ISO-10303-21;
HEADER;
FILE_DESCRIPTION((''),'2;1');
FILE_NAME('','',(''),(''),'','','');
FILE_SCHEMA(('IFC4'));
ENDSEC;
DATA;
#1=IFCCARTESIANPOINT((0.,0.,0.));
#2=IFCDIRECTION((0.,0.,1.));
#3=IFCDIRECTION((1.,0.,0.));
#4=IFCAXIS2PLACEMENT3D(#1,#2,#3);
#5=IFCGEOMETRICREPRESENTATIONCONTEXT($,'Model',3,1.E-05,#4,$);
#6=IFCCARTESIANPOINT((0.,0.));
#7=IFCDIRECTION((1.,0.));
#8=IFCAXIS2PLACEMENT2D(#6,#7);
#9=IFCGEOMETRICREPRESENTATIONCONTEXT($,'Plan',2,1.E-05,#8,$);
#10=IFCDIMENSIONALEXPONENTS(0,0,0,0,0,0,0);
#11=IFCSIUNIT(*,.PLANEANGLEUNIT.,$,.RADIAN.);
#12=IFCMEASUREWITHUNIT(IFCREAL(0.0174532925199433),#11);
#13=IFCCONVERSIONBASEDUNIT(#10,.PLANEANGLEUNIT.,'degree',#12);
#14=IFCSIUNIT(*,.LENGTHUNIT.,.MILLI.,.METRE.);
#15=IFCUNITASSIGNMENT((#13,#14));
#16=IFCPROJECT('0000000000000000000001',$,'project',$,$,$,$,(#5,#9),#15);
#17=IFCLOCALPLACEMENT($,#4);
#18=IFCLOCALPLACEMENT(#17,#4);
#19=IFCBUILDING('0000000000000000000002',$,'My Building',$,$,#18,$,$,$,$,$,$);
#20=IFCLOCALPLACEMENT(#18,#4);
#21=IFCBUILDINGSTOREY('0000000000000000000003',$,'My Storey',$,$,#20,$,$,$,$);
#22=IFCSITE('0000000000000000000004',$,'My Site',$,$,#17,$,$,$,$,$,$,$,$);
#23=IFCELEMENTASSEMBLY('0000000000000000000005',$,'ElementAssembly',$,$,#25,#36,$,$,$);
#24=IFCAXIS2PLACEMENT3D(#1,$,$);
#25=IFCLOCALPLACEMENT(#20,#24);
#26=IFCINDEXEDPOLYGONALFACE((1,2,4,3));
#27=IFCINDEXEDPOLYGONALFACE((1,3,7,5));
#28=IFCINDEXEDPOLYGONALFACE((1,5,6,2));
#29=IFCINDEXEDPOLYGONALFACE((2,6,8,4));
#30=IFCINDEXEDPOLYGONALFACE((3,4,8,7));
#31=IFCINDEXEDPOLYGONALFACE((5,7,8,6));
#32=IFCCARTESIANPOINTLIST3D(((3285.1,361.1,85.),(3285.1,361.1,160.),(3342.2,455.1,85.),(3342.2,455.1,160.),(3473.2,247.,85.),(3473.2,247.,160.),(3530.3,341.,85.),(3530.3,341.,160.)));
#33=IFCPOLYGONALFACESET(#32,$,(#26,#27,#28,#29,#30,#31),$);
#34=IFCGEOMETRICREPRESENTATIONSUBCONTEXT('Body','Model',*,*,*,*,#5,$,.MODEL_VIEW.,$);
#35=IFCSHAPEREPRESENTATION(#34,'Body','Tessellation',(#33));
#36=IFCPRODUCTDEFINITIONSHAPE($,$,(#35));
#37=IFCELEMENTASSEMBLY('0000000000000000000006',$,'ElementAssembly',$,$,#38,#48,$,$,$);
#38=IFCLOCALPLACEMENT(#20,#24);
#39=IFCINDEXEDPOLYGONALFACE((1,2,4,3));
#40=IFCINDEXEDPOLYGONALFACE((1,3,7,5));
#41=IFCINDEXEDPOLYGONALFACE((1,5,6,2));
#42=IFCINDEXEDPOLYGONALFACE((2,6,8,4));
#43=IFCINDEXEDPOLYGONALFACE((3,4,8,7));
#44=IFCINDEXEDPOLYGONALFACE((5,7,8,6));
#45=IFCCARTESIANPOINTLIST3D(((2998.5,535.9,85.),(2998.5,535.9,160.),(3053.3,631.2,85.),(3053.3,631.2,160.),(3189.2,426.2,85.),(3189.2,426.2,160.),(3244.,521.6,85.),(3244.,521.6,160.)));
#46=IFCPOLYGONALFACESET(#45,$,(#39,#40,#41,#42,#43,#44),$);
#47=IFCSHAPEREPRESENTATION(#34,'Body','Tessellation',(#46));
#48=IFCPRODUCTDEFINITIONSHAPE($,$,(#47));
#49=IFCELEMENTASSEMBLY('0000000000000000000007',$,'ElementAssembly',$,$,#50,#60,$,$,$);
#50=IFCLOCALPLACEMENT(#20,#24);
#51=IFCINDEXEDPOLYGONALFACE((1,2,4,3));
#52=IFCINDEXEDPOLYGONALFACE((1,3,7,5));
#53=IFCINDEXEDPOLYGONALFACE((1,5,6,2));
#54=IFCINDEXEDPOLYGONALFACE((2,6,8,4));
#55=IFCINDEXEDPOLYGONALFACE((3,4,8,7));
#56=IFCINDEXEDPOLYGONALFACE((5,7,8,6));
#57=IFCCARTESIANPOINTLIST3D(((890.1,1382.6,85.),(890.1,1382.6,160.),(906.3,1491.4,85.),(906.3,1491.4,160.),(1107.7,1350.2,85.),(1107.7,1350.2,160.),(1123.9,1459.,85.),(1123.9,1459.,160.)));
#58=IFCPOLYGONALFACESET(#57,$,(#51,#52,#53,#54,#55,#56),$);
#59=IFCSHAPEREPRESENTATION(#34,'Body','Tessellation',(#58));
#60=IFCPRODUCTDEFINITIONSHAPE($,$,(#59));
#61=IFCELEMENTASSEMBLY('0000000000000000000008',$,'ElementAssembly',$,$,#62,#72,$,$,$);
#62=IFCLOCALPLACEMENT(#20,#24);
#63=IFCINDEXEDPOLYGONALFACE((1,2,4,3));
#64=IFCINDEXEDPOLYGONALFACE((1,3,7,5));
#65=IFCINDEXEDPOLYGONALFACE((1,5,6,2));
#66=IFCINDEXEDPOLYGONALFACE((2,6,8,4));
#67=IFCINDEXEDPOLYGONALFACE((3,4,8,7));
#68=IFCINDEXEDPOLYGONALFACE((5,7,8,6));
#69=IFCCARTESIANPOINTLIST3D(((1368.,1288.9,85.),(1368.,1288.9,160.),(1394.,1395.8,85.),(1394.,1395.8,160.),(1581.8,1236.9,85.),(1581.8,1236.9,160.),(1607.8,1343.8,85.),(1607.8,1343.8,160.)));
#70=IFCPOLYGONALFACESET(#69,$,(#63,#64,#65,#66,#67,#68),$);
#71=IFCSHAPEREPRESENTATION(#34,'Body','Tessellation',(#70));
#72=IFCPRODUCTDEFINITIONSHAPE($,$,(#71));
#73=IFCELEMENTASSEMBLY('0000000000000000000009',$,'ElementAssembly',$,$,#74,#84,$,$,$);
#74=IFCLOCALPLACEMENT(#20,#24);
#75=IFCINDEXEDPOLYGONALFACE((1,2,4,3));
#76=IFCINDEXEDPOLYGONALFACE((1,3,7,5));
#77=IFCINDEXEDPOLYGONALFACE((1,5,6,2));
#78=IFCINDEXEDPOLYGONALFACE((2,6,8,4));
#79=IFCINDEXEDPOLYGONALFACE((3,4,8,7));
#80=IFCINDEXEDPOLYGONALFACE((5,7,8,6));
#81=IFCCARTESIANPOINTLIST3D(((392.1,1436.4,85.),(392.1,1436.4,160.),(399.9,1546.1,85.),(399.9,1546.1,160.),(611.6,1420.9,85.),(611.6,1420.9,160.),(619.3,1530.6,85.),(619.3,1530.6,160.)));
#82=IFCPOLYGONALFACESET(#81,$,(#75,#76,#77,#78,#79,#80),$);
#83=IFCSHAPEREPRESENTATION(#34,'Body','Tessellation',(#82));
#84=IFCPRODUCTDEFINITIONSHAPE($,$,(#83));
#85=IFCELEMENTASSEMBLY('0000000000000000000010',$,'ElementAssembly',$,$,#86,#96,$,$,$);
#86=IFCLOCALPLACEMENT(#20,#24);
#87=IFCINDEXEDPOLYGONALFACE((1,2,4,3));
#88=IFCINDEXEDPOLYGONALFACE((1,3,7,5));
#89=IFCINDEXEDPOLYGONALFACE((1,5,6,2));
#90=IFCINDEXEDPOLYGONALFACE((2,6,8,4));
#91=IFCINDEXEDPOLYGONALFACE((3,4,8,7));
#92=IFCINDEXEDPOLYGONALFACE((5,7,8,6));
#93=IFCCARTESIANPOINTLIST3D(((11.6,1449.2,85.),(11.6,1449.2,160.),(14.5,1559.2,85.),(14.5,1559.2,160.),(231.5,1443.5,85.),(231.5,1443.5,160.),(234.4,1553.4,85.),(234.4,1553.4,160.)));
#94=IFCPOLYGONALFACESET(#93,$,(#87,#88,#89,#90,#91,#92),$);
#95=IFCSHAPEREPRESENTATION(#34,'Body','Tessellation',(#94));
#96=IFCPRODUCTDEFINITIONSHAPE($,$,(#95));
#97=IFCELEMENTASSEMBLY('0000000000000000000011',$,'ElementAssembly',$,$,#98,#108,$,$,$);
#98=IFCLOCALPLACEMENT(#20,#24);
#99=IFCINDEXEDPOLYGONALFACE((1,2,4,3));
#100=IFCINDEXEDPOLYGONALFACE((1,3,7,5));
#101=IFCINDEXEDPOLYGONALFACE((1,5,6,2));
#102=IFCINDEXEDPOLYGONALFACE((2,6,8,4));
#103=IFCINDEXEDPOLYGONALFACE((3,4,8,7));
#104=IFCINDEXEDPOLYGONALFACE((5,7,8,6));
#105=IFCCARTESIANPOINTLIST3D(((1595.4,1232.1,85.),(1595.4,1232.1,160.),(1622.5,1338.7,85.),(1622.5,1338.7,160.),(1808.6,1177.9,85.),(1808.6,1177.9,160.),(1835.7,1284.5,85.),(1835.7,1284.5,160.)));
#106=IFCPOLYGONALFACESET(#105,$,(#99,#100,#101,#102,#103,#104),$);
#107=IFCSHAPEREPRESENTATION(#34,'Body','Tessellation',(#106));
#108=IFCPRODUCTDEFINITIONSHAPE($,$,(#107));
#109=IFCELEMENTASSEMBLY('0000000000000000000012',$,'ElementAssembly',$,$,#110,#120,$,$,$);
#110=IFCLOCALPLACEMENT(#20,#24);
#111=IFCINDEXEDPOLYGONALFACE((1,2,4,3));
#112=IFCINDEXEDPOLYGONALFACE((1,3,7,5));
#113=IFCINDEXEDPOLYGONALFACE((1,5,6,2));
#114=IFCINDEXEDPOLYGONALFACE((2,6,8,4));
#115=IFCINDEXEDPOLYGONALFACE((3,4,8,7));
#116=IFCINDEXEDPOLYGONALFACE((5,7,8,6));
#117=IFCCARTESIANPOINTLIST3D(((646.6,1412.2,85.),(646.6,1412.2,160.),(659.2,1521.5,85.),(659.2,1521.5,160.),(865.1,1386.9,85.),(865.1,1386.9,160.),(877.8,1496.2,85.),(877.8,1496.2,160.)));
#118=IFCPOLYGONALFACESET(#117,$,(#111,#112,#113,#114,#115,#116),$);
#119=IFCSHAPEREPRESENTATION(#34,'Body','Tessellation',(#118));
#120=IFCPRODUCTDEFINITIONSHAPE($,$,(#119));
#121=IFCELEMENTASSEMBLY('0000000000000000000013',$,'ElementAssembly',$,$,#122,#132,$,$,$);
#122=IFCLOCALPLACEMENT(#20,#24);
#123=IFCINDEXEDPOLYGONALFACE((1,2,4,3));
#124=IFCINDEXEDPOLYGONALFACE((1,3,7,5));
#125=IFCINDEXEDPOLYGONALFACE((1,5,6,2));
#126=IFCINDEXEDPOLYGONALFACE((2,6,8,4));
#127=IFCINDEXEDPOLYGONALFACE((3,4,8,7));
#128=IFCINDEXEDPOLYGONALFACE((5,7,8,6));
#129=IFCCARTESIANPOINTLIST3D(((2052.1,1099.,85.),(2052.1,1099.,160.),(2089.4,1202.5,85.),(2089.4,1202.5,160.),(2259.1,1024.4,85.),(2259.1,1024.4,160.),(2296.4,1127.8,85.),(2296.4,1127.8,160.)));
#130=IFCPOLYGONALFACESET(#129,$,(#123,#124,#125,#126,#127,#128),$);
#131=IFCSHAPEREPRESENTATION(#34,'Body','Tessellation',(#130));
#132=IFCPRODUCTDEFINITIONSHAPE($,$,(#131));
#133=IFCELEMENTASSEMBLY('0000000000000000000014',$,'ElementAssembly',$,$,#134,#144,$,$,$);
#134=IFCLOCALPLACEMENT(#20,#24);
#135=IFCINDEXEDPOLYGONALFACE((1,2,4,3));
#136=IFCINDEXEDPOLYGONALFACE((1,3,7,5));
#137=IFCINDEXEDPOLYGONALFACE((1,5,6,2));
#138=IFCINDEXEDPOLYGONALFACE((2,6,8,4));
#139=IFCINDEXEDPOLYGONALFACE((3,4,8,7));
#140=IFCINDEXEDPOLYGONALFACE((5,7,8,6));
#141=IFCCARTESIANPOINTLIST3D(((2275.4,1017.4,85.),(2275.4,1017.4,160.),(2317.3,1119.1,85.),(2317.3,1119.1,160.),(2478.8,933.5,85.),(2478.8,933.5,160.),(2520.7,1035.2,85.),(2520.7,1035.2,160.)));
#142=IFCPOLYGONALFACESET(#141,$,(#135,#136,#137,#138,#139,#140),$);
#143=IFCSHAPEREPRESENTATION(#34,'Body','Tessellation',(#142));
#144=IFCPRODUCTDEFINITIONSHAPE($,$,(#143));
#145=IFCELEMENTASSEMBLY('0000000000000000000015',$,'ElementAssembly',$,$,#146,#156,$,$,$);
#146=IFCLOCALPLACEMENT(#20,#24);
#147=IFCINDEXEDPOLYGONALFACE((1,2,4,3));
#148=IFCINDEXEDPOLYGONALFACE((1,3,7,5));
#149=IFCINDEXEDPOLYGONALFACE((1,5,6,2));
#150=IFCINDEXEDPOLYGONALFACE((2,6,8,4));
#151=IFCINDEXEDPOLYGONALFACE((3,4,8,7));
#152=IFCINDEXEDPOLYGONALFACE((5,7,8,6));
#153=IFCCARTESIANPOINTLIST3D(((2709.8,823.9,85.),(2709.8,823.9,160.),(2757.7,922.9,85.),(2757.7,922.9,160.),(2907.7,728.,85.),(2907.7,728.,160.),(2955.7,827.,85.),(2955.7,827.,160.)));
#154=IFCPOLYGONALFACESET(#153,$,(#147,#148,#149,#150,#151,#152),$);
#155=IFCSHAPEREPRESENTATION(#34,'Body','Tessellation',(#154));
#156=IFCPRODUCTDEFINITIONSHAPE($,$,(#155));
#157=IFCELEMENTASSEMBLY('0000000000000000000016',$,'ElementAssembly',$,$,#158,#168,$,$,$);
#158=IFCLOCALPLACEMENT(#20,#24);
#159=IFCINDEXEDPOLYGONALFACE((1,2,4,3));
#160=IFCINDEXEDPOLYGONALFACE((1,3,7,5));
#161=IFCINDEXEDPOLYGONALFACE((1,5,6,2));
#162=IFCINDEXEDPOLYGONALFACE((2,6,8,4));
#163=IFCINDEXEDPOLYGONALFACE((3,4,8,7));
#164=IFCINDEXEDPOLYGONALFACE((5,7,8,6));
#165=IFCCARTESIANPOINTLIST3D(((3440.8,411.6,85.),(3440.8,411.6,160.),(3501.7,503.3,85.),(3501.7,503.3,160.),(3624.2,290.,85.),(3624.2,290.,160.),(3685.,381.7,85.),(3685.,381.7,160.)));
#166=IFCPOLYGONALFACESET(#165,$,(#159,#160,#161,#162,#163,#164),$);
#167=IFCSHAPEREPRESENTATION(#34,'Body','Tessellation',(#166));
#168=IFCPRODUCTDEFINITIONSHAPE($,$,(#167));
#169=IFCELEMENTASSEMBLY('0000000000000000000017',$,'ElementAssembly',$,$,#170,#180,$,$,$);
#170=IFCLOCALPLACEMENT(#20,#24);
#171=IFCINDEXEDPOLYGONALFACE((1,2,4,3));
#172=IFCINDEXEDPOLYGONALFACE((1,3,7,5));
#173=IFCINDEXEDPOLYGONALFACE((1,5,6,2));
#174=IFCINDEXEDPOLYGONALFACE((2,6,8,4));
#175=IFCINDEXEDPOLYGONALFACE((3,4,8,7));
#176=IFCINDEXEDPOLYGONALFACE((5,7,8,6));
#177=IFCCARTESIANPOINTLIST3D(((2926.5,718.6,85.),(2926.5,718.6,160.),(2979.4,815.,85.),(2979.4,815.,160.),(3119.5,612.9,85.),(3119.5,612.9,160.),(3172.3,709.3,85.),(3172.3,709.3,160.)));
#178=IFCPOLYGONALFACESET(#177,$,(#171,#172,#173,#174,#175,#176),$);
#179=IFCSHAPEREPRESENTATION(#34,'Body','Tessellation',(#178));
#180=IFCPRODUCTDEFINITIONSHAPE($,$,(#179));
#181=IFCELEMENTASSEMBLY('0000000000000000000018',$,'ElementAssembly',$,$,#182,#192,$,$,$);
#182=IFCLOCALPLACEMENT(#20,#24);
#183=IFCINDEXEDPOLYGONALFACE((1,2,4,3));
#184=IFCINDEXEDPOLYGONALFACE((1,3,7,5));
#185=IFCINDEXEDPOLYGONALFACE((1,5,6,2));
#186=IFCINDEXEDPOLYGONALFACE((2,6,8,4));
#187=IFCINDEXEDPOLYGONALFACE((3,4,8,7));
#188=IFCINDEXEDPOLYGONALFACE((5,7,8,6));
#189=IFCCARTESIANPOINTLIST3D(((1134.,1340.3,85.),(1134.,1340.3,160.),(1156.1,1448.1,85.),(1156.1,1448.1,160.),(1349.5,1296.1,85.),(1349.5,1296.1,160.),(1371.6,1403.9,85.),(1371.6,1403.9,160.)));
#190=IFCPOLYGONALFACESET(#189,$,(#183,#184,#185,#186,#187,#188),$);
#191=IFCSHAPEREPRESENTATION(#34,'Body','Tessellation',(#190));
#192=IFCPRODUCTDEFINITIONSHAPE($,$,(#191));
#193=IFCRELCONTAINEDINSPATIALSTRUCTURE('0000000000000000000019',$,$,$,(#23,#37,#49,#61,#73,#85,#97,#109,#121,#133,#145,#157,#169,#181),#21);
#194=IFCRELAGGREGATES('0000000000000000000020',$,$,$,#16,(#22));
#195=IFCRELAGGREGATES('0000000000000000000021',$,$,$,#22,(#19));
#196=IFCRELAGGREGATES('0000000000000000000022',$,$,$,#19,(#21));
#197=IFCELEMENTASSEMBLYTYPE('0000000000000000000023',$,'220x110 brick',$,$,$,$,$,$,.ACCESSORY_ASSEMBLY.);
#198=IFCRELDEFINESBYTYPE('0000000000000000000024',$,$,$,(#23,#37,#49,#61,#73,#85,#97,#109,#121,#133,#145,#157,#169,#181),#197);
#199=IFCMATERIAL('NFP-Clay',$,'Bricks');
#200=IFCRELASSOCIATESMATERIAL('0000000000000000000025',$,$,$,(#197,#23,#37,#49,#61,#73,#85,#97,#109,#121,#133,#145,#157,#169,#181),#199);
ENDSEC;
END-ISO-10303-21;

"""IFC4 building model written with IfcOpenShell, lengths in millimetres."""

from ifc_helpers import new_model, entity, si_unit, converted_unit, frame, origin_with_axes, origin_2d_with_axis, place, context, subcontext, project, spatial, rectangle, extrude, material, material_profile, profile_set, profile_usage, type_object, element, save


model = new_model("IFC4")

# Units and contexts
model_context = context("Model", 3, precision=1e-05, world=origin_with_axes())
plan_context = context("Plan", 2, precision=1e-05, world=origin_2d_with_axis())
body_context = subcontext(model_context, "Body", "Model", "MODEL_VIEW")
ifc_project = project(units=[converted_unit("PLANEANGLEUNIT", "degree", entity("IfcReal", 0.0174532925199433), si_unit("PLANEANGLEUNIT", "RADIAN"), dimensions=[0, 0, 0, 0, 0, 0, 0]), si_unit("LENGTHUNIT", "METRE", prefix="MILLI")], contexts=[model_context, plan_context])

# Site, building, storey
site_placement = place(None, origin_with_axes())
site = spatial("IfcSite", under=ifc_project, at=site_placement, Name="My Site")
building_placement = place(site_placement, origin_with_axes())
building = spatial("IfcBuilding", under=site, at=building_placement, Name="My Building")
storey_placement = place(building_placement, origin_with_axes())
storey = spatial("IfcBuildingStorey", under=building, at=storey_placement, Name="My Storey")

# Element assemblies
ifc_material_1 = material(Name="NFP-Clay", Category="Bricks")
ifc_material_profile_1 = material_profile(ifc_material_1, rectangle(XDim=220.0, YDim=110.0))
ifc_profile_set_1 = profile_set([ifc_material_profile_1])
element_assembly_type_1 = type_object("IfcElementAssemblyType", Name="220x110 brick", PredefinedType="ACCESSORY_ASSEMBLY", material=ifc_profile_set_1)
ifc_profile_usage_1 = profile_usage(ifc_profile_set_1, cardinal=5)
assembly_1_placement = place(storey_placement, frame((3407.7, 351.0, 85.0), z_axis=(0.0, 0.0, 1.0), x_axis=(0.854897, -0.518798, 0.0)))
element("IfcElementAssembly", 1, at=assembly_1_placement, inside=storey, type_object=element_assembly_type_1, material=ifc_profile_usage_1, Name="ElementAssembly", context=body_context, shape_type="SweptSolid", body=[
    extrude(rectangle(XDim=220.0, YDim=110.0), origin_with_axes(), (0.0, 0.0, 1.0), 75.0),
])
ifc_profile_usage_2 = profile_usage(ifc_profile_set_1, cardinal=5)
assembly_2_placement = place(storey_placement, frame((3121.3, 528.7, 85.0), z_axis=(0.0, 0.0, 1.0), x_axis=(0.86697, -0.498361, 0.0)))
element("IfcElementAssembly", 2, at=assembly_2_placement, inside=storey, type_object=element_assembly_type_1, material=ifc_profile_usage_2, Name="ElementAssembly", context=body_context, shape_type="SweptSolid", body=[
    extrude(rectangle(XDim=220.0, YDim=110.0), origin_with_axes(), (0.0, 0.0, 1.0), 75.0),
])
ifc_profile_usage_3 = profile_usage(ifc_profile_set_1, cardinal=5)
assembly_3_placement = place(storey_placement, frame((1007.0, 1420.8, 85.0), z_axis=(0.0, 0.0, 1.0), x_axis=(0.989094, -0.147289, 0.0)))
element("IfcElementAssembly", 3, at=assembly_3_placement, inside=storey, type_object=element_assembly_type_1, material=ifc_profile_usage_3, Name="ElementAssembly", context=body_context, shape_type="SweptSolid", body=[
    extrude(rectangle(XDim=220.0, YDim=110.0), origin_with_axes(), (0.0, 0.0, 1.0), 75.0),
])
ifc_profile_usage_4 = profile_usage(ifc_profile_set_1, cardinal=5)
assembly_4_placement = place(storey_placement, frame((1487.9, 1316.4, 85.0), z_axis=(0.0, 0.0, 1.0), x_axis=(0.971752, -0.236002, 0.0)))
element("IfcElementAssembly", 4, at=assembly_4_placement, inside=storey, type_object=element_assembly_type_1, material=ifc_profile_usage_4, Name="ElementAssembly", context=body_context, shape_type="SweptSolid", body=[
    extrude(rectangle(XDim=220.0, YDim=110.0), origin_with_axes(), (0.0, 0.0, 1.0), 75.0),
])
ifc_profile_usage_5 = profile_usage(ifc_profile_set_1, cardinal=5)
assembly_5_placement = place(storey_placement, frame((505.7, 1483.5, 85.0), z_axis=(0.0, 0.0, 1.0), x_axis=(0.997514, -0.070472, 0.0)))
element("IfcElementAssembly", 5, at=assembly_5_placement, inside=storey, type_object=element_assembly_type_1, material=ifc_profile_usage_5, Name="ElementAssembly", context=body_context, shape_type="SweptSolid", body=[
    extrude(rectangle(XDim=220.0, YDim=110.0), origin_with_axes(), (0.0, 0.0, 1.0), 75.0),
])
ifc_profile_usage_6 = profile_usage(ifc_profile_set_1, cardinal=5)
assembly_6_placement = place(storey_placement, frame((123.0, 1501.3, 85.0), z_axis=(0.0, 0.0, 1.0), x_axis=(0.999659, -0.0261, 0.0)))
element("IfcElementAssembly", 6, at=assembly_6_placement, inside=storey, type_object=element_assembly_type_1, material=ifc_profile_usage_6, Name="ElementAssembly", context=body_context, shape_type="SweptSolid", body=[
    extrude(rectangle(XDim=220.0, YDim=110.0), origin_with_axes(), (0.0, 0.0, 1.0), 75.0),
])
ifc_profile_usage_7 = profile_usage(ifc_profile_set_1, cardinal=5)
assembly_7_placement = place(storey_placement, frame((1715.6, 1258.3, 85.0), z_axis=(0.0, 0.0, 1.0), x_axis=(0.96918, -0.246355, 0.0)))
element("IfcElementAssembly", 7, at=assembly_7_placement, inside=storey, type_object=element_assembly_type_1, material=ifc_profile_usage_7, Name="ElementAssembly", context=body_context, shape_type="SweptSolid", body=[
    extrude(rectangle(XDim=220.0, YDim=110.0), origin_with_axes(), (0.0, 0.0, 1.0), 75.0),
])
ifc_profile_usage_8 = profile_usage(ifc_profile_set_1, cardinal=5)
assembly_8_placement = place(storey_placement, frame((762.2, 1454.2, 85.0), z_axis=(0.0, 0.0, 1.0), x_axis=(0.993374, -0.114928, 0.0)))
element("IfcElementAssembly", 8, at=assembly_8_placement, inside=storey, type_object=element_assembly_type_1, material=ifc_profile_usage_8, Name="ElementAssembly", context=body_context, shape_type="SweptSolid", body=[
    extrude(rectangle(XDim=220.0, YDim=110.0), origin_with_axes(), (0.0, 0.0, 1.0), 75.0),
])
ifc_profile_usage_9 = profile_usage(ifc_profile_set_1, cardinal=5)
assembly_9_placement = place(storey_placement, frame((2174.3, 1113.4, 85.0), z_axis=(0.0, 0.0, 1.0), x_axis=(0.940653, -0.33937, 0.0)))
element("IfcElementAssembly", 9, at=assembly_9_placement, inside=storey, type_object=element_assembly_type_1, material=ifc_profile_usage_9, Name="ElementAssembly", context=body_context, shape_type="SweptSolid", body=[
    extrude(rectangle(XDim=220.0, YDim=110.0), origin_with_axes(), (0.0, 0.0, 1.0), 75.0),
])
ifc_profile_usage_10 = profile_usage(ifc_profile_set_1, cardinal=5)
assembly_10_placement = place(storey_placement, frame((2398.0, 1026.3, 85.0), z_axis=(0.0, 0.0, 1.0), x_axis=(0.924566, -0.381021, 0.0)))
element("IfcElementAssembly", 10, at=assembly_10_placement, inside=storey, type_object=element_assembly_type_1, material=ifc_profile_usage_10, Name="ElementAssembly", context=body_context, shape_type="SweptSolid", body=[
    extrude(rectangle(XDim=220.0, YDim=110.0), origin_with_axes(), (0.0, 0.0, 1.0), 75.0),
])
ifc_profile_usage_11 = profile_usage(ifc_profile_set_1, cardinal=5)
assembly_11_placement = place(storey_placement, frame((2832.7, 825.5, 85.0), z_axis=(0.0, 0.0, 1.0), x_axis=(0.899844, -0.436212, 0.0)))
element("IfcElementAssembly", 11, at=assembly_11_placement, inside=storey, type_object=element_assembly_type_1, material=ifc_profile_usage_11, Name="ElementAssembly", context=body_context, shape_type="SweptSolid", body=[
    extrude(rectangle(XDim=220.0, YDim=110.0), origin_with_axes(), (0.0, 0.0, 1.0), 75.0),
])
ifc_profile_usage_12 = profile_usage(ifc_profile_set_1, cardinal=5)
assembly_12_placement = place(storey_placement, frame((3562.9, 396.6, 85.0), z_axis=(0.0, 0.0, 1.0), x_axis=(0.833305, -0.552813, 0.0)))
element("IfcElementAssembly", 12, at=assembly_12_placement, inside=storey, type_object=element_assembly_type_1, material=ifc_profile_usage_12, Name="ElementAssembly", context=body_context, shape_type="SweptSolid", body=[
    extrude(rectangle(XDim=220.0, YDim=110.0), origin_with_axes(), (0.0, 0.0, 1.0), 75.0),
])
ifc_profile_usage_13 = profile_usage(ifc_profile_set_1, cardinal=5)
assembly_13_placement = place(storey_placement, frame((3049.4, 714.0, 85.0), z_axis=(0.0, 0.0, 1.0), x_axis=(0.877027, -0.480442, 0.0)))
element("IfcElementAssembly", 13, at=assembly_13_placement, inside=storey, type_object=element_assembly_type_1, material=ifc_profile_usage_13, Name="ElementAssembly", context=body_context, shape_type="SweptSolid", body=[
    extrude(rectangle(XDim=220.0, YDim=110.0), origin_with_axes(), (0.0, 0.0, 1.0), 75.0),
])
ifc_profile_usage_14 = profile_usage(ifc_profile_set_1, cardinal=5)
assembly_14_placement = place(storey_placement, frame((1252.8, 1372.1, 85.0), z_axis=(0.0, 0.0, 1.0), x_axis=(0.979576, -0.201075, 0.0)))
element("IfcElementAssembly", 14, at=assembly_14_placement, inside=storey, type_object=element_assembly_type_1, material=ifc_profile_usage_14, Name="ElementAssembly", context=body_context, shape_type="SweptSolid", body=[
    extrude(rectangle(XDim=220.0, YDim=110.0), origin_with_axes(), (0.0, 0.0, 1.0), 75.0),
])

save(model, "model.ifc")
